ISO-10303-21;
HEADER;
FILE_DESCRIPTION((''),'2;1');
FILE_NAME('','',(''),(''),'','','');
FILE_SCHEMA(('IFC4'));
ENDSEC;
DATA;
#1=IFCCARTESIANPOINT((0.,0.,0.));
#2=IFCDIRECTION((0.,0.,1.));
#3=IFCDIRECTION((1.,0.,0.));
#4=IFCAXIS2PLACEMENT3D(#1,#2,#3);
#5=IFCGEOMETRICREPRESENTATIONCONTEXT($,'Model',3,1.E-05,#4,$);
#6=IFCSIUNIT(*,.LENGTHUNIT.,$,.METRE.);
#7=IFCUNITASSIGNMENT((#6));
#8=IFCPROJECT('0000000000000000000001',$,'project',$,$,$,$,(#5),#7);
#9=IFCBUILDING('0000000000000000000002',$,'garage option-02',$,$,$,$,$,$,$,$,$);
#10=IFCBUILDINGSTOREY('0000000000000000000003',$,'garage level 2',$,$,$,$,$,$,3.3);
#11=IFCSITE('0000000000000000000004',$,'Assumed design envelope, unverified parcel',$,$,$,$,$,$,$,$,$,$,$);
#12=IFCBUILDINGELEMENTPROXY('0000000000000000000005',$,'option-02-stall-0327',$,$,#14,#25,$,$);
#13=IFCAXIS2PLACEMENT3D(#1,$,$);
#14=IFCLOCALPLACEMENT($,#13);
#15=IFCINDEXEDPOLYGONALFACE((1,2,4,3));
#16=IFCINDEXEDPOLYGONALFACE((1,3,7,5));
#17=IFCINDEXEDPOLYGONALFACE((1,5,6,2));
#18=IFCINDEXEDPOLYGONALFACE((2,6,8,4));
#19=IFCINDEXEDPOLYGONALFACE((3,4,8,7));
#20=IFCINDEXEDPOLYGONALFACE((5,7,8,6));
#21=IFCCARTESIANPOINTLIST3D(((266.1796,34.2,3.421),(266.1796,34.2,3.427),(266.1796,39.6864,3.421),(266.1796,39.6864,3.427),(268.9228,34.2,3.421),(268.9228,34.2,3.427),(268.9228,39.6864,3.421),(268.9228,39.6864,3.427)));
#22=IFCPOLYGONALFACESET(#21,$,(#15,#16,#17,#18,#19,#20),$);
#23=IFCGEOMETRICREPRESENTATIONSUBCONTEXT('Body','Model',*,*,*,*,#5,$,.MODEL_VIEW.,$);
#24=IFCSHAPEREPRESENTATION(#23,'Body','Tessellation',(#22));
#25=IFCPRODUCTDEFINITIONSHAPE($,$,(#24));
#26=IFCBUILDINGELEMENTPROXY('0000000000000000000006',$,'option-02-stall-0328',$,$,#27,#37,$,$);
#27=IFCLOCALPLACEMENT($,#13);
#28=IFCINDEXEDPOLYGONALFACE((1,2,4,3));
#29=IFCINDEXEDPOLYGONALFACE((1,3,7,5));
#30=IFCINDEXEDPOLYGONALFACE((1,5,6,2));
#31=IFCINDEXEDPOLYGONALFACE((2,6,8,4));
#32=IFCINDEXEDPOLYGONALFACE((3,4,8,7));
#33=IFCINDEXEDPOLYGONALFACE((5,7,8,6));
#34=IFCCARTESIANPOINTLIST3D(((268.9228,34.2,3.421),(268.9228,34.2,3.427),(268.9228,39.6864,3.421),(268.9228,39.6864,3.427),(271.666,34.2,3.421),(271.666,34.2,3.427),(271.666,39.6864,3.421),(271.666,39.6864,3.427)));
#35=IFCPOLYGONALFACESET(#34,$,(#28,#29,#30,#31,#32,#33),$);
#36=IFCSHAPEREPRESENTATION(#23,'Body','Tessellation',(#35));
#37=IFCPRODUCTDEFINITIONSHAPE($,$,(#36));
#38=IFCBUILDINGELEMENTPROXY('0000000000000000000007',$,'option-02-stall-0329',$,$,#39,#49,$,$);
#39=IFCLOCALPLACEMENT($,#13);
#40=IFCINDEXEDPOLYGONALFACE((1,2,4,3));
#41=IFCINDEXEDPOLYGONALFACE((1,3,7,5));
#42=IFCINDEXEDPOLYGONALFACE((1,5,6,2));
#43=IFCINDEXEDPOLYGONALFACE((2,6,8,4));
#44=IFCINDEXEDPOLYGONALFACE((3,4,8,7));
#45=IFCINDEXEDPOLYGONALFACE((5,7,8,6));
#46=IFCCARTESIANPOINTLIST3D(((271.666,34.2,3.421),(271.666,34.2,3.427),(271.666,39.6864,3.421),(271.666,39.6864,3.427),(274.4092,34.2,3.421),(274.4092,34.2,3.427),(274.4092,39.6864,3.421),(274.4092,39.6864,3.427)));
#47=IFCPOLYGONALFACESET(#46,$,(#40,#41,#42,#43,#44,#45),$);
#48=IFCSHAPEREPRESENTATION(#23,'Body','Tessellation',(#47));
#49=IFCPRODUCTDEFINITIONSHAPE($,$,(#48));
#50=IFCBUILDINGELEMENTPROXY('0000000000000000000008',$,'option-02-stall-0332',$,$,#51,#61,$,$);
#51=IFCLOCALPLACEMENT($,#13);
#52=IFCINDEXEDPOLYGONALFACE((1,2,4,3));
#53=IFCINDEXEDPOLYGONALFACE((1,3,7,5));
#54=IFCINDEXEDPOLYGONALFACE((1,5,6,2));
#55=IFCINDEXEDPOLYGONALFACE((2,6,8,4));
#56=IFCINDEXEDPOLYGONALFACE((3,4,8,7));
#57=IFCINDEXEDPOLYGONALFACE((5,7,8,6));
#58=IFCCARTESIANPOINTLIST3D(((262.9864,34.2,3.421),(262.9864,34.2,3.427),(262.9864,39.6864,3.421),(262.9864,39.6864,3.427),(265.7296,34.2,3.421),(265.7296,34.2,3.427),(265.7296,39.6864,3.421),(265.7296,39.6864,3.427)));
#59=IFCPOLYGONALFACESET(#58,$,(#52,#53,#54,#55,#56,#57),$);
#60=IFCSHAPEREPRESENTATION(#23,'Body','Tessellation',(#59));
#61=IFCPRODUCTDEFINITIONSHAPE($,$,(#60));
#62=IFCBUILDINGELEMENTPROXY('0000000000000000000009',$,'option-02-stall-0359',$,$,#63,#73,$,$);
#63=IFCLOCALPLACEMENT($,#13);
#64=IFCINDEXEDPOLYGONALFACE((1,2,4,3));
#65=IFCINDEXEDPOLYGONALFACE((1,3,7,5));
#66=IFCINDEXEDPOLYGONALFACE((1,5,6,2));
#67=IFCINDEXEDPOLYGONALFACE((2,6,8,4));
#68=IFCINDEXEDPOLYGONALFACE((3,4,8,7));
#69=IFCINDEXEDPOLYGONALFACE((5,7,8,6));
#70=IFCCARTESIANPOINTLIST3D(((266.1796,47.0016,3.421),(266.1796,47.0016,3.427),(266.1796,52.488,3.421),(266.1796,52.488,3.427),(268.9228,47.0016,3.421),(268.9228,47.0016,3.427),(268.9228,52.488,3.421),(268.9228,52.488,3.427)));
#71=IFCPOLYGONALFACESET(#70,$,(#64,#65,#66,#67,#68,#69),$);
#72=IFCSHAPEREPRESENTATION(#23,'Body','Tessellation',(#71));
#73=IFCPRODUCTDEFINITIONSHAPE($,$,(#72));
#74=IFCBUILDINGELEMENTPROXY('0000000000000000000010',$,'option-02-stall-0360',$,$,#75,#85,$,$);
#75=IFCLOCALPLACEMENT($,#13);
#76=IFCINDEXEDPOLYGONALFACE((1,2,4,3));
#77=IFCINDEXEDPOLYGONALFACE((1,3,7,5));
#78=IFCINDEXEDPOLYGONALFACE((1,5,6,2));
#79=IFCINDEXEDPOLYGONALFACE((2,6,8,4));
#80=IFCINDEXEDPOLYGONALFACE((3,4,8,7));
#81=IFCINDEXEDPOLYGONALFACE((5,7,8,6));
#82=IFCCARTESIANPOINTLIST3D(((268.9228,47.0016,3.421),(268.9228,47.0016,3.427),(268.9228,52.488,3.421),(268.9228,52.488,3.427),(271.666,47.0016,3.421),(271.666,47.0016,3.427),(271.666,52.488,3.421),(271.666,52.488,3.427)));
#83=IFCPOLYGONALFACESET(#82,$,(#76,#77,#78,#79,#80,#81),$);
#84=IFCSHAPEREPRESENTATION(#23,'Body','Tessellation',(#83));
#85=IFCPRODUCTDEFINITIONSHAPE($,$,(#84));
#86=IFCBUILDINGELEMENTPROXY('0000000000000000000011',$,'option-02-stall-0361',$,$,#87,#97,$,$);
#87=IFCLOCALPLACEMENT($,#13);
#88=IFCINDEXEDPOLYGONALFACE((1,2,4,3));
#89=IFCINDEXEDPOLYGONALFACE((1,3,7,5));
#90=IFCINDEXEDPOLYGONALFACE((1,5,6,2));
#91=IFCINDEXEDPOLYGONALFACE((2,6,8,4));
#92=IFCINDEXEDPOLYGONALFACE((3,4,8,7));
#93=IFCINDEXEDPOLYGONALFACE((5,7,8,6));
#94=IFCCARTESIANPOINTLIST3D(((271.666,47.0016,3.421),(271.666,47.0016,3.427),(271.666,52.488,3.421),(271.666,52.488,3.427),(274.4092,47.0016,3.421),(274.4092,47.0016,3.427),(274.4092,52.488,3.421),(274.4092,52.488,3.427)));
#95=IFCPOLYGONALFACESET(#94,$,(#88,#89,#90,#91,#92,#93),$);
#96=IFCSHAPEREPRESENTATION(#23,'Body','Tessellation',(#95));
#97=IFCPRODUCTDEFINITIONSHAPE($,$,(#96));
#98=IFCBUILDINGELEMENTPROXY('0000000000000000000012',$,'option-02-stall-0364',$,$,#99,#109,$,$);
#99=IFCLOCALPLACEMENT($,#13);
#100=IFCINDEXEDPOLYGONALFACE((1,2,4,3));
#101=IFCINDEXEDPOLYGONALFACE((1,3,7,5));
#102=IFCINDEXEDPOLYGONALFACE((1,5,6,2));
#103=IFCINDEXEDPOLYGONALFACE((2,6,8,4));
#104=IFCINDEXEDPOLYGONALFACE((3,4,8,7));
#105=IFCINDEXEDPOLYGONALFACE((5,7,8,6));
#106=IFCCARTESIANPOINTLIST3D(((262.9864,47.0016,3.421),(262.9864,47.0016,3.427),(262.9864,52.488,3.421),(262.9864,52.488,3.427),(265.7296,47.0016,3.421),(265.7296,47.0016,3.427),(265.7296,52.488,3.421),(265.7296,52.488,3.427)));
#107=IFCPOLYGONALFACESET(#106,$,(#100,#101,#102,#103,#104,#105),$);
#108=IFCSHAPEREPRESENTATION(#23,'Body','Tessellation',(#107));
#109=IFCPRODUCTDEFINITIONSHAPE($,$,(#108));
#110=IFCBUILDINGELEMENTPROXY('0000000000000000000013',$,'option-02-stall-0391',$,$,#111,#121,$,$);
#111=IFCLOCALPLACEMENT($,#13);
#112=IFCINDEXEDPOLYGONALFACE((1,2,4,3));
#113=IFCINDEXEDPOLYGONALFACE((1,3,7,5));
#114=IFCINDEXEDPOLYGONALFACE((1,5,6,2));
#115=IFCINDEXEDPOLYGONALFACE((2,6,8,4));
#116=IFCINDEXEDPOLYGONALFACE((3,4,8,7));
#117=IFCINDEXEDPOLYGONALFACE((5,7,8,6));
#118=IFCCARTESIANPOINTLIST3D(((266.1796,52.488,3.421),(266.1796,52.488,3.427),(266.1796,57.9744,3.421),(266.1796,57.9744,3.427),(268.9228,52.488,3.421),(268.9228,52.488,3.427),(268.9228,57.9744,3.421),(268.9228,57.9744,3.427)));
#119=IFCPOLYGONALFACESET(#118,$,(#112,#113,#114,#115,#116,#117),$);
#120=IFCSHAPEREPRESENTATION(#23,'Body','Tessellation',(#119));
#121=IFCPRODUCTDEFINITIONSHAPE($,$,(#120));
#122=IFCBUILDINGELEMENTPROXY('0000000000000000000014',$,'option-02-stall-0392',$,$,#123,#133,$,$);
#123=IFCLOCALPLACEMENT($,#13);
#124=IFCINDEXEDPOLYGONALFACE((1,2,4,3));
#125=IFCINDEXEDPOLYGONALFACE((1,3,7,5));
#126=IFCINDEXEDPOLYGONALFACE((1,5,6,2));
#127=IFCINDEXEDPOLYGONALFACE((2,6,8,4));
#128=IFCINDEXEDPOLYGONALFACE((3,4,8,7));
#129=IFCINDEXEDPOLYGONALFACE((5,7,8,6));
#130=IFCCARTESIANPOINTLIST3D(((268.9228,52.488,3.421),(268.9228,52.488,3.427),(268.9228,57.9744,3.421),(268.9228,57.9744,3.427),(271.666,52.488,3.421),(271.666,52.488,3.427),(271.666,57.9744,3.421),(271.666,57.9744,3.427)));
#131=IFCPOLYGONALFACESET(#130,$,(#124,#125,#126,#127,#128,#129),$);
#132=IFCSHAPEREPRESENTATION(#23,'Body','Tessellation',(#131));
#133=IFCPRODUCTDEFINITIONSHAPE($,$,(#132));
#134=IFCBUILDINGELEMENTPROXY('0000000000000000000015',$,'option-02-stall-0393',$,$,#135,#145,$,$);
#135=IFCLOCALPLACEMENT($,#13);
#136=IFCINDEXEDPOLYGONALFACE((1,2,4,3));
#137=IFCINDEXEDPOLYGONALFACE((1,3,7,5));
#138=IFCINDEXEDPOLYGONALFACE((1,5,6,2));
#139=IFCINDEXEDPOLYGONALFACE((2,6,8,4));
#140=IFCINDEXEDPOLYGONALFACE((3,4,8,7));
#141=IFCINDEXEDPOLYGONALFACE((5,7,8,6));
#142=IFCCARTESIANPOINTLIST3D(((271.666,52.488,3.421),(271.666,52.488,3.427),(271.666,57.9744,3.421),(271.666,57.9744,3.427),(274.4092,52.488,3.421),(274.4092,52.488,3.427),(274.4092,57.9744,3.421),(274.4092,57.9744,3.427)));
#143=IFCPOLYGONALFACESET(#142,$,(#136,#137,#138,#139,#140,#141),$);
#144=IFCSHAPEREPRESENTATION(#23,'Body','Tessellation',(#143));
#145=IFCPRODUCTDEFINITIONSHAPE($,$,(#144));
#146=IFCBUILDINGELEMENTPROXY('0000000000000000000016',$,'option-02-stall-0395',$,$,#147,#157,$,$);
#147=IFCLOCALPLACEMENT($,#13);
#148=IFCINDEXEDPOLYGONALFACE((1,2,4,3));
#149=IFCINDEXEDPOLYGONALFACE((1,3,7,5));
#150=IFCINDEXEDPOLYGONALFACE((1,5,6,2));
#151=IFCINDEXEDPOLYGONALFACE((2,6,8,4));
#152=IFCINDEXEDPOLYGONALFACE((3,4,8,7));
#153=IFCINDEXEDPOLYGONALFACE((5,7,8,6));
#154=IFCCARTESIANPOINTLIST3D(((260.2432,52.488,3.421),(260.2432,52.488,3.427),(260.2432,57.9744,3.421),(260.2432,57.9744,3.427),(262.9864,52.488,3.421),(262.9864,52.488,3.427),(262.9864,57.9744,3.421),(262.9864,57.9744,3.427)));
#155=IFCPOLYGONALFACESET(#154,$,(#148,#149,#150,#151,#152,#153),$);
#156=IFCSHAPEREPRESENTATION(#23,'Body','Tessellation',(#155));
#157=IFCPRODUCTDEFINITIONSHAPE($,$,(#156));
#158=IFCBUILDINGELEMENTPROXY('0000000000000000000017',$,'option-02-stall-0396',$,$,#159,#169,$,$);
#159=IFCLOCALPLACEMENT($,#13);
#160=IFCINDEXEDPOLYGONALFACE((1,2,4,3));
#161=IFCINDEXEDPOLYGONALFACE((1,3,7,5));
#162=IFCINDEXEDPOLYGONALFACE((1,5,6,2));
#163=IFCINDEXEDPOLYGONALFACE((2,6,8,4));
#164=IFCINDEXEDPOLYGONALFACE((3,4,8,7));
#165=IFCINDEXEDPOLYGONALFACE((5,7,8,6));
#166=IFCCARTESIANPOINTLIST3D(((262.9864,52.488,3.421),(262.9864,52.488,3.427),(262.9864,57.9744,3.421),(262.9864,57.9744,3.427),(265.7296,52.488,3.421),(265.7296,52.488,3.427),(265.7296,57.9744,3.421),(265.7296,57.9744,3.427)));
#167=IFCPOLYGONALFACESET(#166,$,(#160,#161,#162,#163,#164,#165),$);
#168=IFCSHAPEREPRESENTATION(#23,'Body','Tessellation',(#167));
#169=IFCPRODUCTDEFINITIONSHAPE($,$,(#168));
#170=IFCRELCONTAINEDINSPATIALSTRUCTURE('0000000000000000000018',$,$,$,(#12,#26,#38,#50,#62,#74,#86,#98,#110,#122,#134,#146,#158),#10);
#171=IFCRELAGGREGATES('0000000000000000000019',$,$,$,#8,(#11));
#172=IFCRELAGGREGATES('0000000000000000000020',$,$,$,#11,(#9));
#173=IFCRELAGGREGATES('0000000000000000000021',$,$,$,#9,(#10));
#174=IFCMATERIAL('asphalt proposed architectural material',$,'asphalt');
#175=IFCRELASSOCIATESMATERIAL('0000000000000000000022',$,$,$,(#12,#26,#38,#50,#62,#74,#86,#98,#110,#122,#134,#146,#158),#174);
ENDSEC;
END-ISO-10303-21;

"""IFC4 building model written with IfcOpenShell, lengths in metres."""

from ifc_helpers import new_model, si_unit, frame, origin_with_axes, place, context, subcontext, project, spatial, rectangle, extrude, material, element, save


model = new_model("IFC4")

# Units and contexts
model_context = context("Model", 3, precision=1e-05, world=origin_with_axes())
body_context = subcontext(model_context, "Body", "Model", "MODEL_VIEW")
ifc_project = project(units=[si_unit("LENGTHUNIT", "METRE")], contexts=[model_context])

# Site, building, storey
site = spatial("IfcSite", under=ifc_project, Name="Assumed design envelope, unverified parcel")
building = spatial("IfcBuilding", under=site, Name="garage option-02")
storey = spatial("IfcBuildingStorey", under=building, Name="garage level 2", Elevation=3.3)

# Building element proxies
ifc_material_1 = material(Name="asphalt proposed architectural material", Category="asphalt")
for number, where, z_axis, x_axis, name in (
    (1, (267.5512, 36.9432, 3.421), (0.0, 0.0, 1.0), (1.0, 0.0, 0.0), "option-02-stall-0327"),
    (2, (270.2944, 36.9432, 3.421), (0.0, 0.0, 1.0), (1.0, 0.0, 0.0), "option-02-stall-0328"),
    (3, (273.0376, 36.9432, 3.421), (0.0, 0.0, 1.0), (1.0, 0.0, 0.0), "option-02-stall-0329"),
    (4, (264.358, 36.9432, 3.421), (0.0, 0.0, 1.0), (1.0, 0.0, 0.0), "option-02-stall-0332"),
    (5, (267.5512, 49.7448, 3.421), (0.0, 0.0, 1.0), (1.0, 0.0, 0.0), "option-02-stall-0359"),
    (6, (270.2944, 49.7448, 3.421), (0.0, 0.0, 1.0), (1.0, 0.0, 0.0), "option-02-stall-0360"),
    (7, (273.0376, 49.7448, 3.421), (0.0, 0.0, 1.0), (1.0, 0.0, 0.0), "option-02-stall-0361"),
    (8, (264.358, 49.7448, 3.421), (0.0, 0.0, 1.0), (1.0, 0.0, 0.0), "option-02-stall-0364"),
):
    element("IfcBuildingElementProxy", number, at=place(None, frame(where, z_axis=z_axis, x_axis=x_axis)), inside=storey, material=ifc_material_1, Name=name, context=body_context, shape_type="SweptSolid", body=[
        extrude(rectangle(XDim=2.7432, YDim=5.4864), origin_with_axes(), (0.0, 0.0, 1.0), 0.006),
    ])
for number, where, z_axis, x_axis, name in (
    (9, (267.5512, 55.2312, 3.421), (0.0, 0.0, 1.0), (1.0, 0.0, 0.0), "option-02-stall-0391"),
    (10, (270.2944, 55.2312, 3.421), (0.0, 0.0, 1.0), (1.0, 0.0, 0.0), "option-02-stall-0392"),
    (11, (273.0376, 55.2312, 3.421), (0.0, 0.0, 1.0), (1.0, 0.0, 0.0), "option-02-stall-0393"),
    (12, (261.6148, 55.2312, 3.421), (0.0, 0.0, 1.0), (1.0, 0.0, 0.0), "option-02-stall-0395"),
    (13, (264.358, 55.2312, 3.421), (0.0, 0.0, 1.0), (1.0, 0.0, 0.0), "option-02-stall-0396"),
):
    element("IfcBuildingElementProxy", number, at=place(None, frame(where, z_axis=z_axis, x_axis=x_axis)), inside=storey, material=ifc_material_1, Name=name, context=body_context, shape_type="SweptSolid", body=[
        extrude(rectangle(XDim=2.7432, YDim=5.4864), origin_with_axes(), (0.0, 0.0, 1.0), 0.006),
    ])

save(model, "model.ifc")
